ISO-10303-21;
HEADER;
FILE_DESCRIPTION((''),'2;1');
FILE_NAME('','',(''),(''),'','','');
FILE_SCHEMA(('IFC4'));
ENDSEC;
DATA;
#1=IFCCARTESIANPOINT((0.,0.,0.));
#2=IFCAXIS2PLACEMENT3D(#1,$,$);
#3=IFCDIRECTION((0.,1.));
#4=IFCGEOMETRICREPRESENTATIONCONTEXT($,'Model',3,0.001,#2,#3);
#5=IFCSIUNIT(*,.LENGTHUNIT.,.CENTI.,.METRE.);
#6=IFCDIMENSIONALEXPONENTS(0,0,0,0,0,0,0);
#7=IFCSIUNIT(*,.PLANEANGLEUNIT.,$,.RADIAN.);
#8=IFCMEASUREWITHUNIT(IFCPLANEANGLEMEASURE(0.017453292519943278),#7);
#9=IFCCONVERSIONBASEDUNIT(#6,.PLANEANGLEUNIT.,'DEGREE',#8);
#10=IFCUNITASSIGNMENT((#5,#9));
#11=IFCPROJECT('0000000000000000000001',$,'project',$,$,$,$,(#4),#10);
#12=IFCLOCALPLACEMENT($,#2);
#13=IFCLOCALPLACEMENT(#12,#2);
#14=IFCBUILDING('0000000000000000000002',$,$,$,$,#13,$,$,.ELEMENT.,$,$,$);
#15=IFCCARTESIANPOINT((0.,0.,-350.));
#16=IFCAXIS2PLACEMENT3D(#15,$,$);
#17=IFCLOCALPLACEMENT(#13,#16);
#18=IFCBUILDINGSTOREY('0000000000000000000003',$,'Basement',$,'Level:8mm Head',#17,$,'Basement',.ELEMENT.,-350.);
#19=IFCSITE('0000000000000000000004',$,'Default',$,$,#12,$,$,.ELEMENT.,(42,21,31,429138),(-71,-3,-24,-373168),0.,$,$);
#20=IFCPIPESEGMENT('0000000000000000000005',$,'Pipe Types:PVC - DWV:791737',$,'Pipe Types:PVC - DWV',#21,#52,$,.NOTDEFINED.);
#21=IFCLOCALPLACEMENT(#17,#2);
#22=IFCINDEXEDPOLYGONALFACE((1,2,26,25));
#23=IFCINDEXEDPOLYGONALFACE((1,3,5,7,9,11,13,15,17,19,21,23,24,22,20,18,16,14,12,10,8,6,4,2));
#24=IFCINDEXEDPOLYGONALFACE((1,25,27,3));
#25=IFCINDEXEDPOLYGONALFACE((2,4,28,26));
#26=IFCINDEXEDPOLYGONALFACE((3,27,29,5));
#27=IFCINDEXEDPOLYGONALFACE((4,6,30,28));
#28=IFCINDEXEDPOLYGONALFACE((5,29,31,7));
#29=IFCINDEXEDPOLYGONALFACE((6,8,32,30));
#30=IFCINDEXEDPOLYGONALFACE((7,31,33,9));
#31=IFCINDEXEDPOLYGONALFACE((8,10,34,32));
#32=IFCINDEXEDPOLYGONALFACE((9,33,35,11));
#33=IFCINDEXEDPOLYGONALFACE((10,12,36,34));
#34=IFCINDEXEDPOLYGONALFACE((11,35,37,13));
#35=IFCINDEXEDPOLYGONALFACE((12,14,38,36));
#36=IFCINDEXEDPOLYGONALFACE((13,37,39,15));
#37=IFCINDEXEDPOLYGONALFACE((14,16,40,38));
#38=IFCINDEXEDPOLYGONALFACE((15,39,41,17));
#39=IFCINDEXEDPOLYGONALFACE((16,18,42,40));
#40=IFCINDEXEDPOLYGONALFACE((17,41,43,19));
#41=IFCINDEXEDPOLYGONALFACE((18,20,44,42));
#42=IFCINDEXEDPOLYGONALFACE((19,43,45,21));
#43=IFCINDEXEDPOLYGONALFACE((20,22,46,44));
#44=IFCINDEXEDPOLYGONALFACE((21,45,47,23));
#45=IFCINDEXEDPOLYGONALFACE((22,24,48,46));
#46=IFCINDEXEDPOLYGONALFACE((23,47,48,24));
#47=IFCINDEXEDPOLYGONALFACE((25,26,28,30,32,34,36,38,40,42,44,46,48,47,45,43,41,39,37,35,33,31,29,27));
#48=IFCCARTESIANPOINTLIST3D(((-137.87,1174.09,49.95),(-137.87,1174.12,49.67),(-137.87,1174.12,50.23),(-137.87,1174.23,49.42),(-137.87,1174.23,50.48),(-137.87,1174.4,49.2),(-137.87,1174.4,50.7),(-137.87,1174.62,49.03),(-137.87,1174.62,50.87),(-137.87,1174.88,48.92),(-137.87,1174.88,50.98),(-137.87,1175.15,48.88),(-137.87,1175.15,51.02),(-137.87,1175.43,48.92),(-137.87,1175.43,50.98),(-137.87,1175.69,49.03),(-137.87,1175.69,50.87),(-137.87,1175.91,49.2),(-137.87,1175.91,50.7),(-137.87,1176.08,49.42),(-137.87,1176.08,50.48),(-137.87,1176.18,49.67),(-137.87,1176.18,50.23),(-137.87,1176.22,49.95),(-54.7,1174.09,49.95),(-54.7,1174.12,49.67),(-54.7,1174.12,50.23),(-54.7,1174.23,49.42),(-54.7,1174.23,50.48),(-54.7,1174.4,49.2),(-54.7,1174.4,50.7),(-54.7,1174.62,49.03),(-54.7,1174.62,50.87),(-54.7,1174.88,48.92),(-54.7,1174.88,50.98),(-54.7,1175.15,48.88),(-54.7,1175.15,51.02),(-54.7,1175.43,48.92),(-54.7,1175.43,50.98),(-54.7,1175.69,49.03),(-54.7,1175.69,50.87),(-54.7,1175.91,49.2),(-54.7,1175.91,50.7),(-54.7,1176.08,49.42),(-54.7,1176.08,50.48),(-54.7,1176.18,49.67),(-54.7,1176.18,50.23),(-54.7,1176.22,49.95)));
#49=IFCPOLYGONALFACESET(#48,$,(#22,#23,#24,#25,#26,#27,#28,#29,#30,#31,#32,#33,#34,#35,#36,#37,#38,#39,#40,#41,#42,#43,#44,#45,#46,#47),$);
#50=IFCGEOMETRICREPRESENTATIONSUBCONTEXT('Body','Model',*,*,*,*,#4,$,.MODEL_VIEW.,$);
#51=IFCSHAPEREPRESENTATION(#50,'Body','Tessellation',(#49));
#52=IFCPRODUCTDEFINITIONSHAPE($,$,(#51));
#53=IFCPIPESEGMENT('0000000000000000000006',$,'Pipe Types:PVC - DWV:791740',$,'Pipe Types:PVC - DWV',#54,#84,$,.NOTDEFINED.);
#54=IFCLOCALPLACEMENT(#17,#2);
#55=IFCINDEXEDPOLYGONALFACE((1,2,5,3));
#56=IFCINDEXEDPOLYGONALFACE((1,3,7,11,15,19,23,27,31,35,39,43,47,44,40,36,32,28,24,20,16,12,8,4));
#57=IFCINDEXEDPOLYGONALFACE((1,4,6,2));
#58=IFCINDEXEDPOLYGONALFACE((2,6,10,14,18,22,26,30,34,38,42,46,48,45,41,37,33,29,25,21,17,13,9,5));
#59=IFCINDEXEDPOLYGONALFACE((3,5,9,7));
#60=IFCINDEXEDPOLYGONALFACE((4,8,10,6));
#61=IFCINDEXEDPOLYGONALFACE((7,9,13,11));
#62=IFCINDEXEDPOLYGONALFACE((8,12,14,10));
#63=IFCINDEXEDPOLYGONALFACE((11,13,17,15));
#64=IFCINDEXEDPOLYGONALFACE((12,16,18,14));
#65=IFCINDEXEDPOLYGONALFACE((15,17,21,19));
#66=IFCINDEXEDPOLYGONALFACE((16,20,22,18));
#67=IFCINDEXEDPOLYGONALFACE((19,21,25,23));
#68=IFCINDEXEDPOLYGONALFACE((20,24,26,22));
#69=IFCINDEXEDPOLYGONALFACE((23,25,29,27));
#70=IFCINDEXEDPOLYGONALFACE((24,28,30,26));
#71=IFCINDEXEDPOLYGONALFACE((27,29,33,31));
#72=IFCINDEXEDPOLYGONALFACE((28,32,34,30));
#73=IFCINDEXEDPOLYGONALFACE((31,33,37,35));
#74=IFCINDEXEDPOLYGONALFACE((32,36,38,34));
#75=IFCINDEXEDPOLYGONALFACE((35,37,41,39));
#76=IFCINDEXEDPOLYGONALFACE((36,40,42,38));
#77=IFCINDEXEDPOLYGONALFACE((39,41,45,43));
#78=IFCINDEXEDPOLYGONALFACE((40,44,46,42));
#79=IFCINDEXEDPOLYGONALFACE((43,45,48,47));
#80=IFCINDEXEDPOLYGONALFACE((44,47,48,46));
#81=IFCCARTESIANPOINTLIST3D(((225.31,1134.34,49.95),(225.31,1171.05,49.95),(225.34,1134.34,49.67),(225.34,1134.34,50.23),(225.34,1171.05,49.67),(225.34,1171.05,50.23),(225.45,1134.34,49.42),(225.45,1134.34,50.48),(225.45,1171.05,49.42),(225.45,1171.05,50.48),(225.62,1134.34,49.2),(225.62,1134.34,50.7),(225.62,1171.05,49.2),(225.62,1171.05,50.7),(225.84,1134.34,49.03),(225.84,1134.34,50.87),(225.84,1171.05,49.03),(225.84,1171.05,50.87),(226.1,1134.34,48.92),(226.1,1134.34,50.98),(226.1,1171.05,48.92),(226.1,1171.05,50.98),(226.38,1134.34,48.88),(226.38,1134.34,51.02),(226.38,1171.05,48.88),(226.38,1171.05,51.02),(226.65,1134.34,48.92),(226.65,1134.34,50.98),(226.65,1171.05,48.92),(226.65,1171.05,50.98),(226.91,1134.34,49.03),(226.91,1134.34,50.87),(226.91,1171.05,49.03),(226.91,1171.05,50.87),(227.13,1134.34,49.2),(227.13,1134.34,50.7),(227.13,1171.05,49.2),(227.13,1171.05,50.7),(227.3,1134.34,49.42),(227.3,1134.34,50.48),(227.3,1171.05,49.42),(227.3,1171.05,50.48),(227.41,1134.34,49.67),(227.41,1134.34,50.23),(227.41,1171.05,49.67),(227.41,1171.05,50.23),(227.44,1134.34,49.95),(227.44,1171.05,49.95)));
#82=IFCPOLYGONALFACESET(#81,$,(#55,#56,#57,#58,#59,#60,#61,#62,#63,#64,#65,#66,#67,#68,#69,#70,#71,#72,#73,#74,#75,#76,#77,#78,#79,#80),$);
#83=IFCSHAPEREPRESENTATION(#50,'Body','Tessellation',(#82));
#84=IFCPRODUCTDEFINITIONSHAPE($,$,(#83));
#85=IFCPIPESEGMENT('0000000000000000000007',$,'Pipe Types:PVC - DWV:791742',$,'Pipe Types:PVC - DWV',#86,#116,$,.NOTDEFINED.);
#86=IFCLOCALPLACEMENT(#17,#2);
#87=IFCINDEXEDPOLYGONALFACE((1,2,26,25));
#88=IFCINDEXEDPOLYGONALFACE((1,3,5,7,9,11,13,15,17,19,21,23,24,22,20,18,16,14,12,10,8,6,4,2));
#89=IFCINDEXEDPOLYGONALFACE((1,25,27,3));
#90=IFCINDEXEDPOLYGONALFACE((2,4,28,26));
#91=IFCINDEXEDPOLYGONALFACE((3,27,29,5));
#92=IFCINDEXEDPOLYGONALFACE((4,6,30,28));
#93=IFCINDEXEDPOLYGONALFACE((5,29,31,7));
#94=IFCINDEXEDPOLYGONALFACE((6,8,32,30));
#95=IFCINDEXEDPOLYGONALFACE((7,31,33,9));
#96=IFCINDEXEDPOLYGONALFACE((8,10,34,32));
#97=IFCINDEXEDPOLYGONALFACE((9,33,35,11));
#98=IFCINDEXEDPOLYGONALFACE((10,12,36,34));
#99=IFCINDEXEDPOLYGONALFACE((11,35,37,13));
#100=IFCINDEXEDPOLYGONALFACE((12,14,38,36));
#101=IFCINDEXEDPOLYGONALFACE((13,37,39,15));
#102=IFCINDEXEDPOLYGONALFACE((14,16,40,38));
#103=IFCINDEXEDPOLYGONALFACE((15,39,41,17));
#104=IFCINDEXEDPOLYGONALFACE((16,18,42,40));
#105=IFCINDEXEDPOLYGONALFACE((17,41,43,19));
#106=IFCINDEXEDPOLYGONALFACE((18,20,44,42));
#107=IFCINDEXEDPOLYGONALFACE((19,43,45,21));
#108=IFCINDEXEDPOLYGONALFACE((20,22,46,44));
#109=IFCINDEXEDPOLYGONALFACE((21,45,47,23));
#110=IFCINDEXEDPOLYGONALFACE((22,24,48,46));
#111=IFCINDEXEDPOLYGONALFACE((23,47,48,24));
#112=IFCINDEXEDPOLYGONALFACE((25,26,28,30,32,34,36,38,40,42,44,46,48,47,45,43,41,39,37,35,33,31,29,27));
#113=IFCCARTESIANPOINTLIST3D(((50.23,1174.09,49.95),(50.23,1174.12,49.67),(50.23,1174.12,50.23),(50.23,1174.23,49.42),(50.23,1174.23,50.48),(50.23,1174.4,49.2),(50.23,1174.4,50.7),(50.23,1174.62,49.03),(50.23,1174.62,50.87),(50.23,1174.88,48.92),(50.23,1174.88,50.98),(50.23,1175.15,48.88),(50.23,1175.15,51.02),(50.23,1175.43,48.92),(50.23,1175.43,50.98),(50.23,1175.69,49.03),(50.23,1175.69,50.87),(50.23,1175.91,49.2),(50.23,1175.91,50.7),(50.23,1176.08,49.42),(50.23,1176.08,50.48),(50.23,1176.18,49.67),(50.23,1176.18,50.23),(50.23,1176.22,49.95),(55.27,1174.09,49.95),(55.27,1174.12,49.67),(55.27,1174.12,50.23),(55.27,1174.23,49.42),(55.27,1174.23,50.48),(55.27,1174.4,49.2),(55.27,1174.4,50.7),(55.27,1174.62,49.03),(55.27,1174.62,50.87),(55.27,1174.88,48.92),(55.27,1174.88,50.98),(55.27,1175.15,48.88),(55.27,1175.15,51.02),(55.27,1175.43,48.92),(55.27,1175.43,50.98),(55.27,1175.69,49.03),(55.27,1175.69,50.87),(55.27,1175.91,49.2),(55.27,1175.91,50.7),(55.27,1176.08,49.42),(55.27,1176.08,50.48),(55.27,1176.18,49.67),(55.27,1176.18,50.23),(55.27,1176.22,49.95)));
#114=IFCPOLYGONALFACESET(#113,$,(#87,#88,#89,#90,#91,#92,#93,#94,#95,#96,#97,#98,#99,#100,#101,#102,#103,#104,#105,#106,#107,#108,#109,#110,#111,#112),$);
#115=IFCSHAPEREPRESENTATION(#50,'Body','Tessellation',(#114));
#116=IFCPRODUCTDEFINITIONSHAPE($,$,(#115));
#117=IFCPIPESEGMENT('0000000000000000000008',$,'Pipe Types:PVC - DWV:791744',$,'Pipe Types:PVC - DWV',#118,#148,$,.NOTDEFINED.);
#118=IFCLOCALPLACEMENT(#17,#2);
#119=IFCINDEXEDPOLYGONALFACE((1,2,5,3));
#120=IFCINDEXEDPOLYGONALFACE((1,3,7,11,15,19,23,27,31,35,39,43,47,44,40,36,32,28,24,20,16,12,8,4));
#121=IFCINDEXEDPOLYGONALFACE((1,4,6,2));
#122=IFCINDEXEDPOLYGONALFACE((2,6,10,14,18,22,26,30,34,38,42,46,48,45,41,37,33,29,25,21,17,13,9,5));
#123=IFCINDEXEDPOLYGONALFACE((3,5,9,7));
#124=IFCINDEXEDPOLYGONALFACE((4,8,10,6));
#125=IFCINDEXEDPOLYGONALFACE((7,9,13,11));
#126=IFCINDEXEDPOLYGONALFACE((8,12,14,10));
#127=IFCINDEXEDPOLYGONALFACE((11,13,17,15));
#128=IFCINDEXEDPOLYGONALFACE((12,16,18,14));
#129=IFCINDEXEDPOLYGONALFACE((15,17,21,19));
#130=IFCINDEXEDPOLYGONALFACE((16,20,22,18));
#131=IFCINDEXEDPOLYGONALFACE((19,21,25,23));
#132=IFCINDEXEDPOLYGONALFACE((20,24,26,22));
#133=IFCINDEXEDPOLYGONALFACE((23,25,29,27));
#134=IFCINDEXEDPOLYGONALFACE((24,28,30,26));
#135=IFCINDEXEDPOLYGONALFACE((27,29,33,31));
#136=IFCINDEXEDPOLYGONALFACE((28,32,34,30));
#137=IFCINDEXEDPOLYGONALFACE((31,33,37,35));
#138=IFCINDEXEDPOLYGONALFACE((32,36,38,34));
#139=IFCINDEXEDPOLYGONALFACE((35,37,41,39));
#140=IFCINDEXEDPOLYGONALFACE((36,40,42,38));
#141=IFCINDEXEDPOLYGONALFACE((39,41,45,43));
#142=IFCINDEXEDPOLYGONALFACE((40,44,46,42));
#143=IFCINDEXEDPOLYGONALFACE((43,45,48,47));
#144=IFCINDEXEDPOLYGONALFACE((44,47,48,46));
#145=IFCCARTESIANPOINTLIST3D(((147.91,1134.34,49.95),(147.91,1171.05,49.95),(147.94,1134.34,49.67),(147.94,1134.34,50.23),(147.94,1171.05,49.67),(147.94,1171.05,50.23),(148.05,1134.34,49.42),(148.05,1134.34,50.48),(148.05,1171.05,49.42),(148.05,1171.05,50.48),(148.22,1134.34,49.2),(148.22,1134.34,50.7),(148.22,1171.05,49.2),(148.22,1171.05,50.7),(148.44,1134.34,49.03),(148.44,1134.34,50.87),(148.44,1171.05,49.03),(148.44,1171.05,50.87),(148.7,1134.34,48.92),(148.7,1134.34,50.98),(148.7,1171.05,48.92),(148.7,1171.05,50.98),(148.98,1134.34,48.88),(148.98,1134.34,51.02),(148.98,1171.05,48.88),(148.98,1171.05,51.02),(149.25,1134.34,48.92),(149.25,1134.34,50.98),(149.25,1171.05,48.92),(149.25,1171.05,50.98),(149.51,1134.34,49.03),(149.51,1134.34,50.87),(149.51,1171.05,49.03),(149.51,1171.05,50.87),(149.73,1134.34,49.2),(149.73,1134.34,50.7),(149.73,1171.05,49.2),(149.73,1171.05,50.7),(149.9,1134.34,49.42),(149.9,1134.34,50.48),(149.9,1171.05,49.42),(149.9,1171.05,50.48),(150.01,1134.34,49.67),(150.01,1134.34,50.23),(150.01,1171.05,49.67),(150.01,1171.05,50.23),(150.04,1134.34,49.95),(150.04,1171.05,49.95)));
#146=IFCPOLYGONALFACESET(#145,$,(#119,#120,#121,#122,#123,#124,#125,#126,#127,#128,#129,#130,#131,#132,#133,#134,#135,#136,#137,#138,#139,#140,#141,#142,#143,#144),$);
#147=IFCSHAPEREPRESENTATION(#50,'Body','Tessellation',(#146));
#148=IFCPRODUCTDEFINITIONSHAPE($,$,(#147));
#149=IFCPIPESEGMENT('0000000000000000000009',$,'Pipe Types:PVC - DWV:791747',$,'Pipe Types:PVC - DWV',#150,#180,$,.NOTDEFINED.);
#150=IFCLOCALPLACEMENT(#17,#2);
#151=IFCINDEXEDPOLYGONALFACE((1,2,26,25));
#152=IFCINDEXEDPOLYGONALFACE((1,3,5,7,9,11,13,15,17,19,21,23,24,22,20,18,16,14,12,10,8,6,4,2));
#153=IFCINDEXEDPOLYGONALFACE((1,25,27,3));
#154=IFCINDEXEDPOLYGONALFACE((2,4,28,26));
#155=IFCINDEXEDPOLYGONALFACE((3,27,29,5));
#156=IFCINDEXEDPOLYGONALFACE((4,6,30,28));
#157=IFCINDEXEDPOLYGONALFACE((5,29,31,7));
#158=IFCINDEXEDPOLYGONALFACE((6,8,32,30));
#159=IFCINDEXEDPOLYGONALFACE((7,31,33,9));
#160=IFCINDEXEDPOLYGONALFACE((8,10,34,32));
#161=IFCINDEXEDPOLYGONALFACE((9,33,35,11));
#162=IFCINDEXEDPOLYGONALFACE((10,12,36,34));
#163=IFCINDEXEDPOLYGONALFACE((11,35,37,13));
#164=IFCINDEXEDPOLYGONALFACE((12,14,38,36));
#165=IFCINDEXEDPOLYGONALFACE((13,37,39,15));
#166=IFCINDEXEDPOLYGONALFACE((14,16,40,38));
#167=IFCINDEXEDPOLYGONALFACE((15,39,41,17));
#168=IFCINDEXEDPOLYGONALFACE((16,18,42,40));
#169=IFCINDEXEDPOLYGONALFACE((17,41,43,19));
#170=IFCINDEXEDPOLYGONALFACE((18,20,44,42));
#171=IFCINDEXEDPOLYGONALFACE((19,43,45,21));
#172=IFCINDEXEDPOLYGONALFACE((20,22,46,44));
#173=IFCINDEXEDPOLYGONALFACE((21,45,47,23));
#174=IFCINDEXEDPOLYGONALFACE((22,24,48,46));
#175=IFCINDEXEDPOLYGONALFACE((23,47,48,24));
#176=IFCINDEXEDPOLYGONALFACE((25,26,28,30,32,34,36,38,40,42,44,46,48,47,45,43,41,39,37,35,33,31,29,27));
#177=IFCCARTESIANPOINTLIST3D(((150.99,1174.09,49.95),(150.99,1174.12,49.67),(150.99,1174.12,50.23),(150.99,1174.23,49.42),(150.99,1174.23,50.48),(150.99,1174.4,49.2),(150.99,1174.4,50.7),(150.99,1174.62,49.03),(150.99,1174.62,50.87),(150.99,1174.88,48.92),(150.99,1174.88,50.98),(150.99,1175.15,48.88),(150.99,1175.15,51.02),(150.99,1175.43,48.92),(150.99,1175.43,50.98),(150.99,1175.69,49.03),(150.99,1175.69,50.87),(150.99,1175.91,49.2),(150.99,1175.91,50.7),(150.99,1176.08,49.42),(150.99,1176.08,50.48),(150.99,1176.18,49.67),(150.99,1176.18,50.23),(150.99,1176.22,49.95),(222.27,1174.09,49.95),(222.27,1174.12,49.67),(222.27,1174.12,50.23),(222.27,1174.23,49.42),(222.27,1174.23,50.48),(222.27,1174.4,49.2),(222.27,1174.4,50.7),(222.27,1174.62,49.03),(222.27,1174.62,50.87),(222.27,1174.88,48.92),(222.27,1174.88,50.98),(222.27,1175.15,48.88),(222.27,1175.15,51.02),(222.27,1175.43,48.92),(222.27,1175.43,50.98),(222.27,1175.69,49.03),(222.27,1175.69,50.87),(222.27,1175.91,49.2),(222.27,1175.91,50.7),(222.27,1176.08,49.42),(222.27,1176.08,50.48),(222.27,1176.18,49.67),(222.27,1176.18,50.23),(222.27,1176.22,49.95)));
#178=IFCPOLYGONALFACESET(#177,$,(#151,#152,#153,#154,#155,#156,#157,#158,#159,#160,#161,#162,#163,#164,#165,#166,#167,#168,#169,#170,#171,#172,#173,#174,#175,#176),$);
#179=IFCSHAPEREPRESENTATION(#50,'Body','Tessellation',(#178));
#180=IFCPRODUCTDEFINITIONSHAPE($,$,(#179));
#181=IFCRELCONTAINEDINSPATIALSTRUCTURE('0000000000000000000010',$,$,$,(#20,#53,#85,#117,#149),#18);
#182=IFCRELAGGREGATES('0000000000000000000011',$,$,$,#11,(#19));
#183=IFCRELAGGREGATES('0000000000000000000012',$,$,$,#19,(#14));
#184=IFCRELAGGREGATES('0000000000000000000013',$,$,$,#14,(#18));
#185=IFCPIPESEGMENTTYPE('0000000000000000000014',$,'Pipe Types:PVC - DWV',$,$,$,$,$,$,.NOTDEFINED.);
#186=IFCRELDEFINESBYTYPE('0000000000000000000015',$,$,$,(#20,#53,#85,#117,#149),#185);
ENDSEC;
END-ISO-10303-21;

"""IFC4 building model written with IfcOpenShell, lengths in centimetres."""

from ifc_helpers import new_model, entity, si_unit, converted_unit, direction, frame, origin, place, context, subcontext, project, spatial, arc, indexed_curve, outline, extrude, type_object, element, save


model = new_model("IFC4")

# Units and contexts
model_context = context("Model", 3, precision=0.001, world=origin(), true_north=direction((0.0, 1.0)))
body_context = subcontext(model_context, "Body", "Model", "MODEL_VIEW")
ifc_project = project(units=[si_unit("LENGTHUNIT", "METRE", prefix="CENTI"), converted_unit("PLANEANGLEUNIT", "DEGREE", entity("IfcPlaneAngleMeasure", 0.017453292519943278), si_unit("PLANEANGLEUNIT", "RADIAN"), dimensions=[0, 0, 0, 0, 0, 0, 0])], contexts=[model_context])

# Site, building, storey
site_placement = place(None, origin())
site = spatial("IfcSite", under=ifc_project, at=site_placement, Name="Default", CompositionType="ELEMENT", RefLatitude=(42, 21, 31, 429138), RefLongitude=(-71, -3, -24, -373168), RefElevation=0.0)
building_placement = place(site_placement, origin())
building = spatial("IfcBuilding", under=site, at=building_placement, CompositionType="ELEMENT")
storey_placement = place(building_placement, frame((0.0, 0.0, -350.0)))
storey = spatial("IfcBuildingStorey", under=building, at=storey_placement, Name="Basement", ObjectType="Level:8mm Head", LongName="Basement", CompositionType="ELEMENT", Elevation=-350.0)

# Pipe segments
pipe_segment_type = type_object("IfcPipeSegmentType", Name="Pipe Types:PVC - DWV", PredefinedType="NOTDEFINED")
pipe_segment_1_placement = place(storey_placement, origin())
element("IfcPipeSegment", 1, at=pipe_segment_1_placement, inside=storey, type_object=pipe_segment_type, Name="Pipe Types:PVC - DWV:791737", ObjectType="Pipe Types:PVC - DWV", PredefinedType="NOTDEFINED", context=body_context, shape_type="SweptSolid", body=[
    extrude(outline(indexed_curve([(1.07, 0.0), (0.75, 0.75), (0.0, 1.07), (-0.75, 0.75), (-1.07, 0.0), (-0.75, -0.75), (0.0, -1.07), (0.75, -0.75)], segments=[arc(1, 2, 3), arc(3, 4, 5), arc(5, 6, 7), arc(7, 8, 1)], self_intersect=False)), frame((-137.87, 1175.15, 49.95), z_axis=(1.0, 0.0, 0.0), x_axis=(0.0, -1.0, 0.0)), (0.0, 0.0, 1.0), 83.17),
])
pipe_segment_2_placement = place(storey_placement, origin())
element("IfcPipeSegment", 2, at=pipe_segment_2_placement, inside=storey, type_object=pipe_segment_type, Name="Pipe Types:PVC - DWV:791740", ObjectType="Pipe Types:PVC - DWV", PredefinedType="NOTDEFINED", context=body_context, shape_type="SweptSolid", body=[
    extrude(outline(indexed_curve([(1.07, 0.0), (0.75, 0.75), (0.0, 1.07), (-0.75, 0.75), (-1.07, 0.0), (-0.75, -0.75), (0.0, -1.07), (0.75, -0.75)], segments=[arc(1, 2, 3), arc(3, 4, 5), arc(5, 6, 7), arc(7, 8, 1)], self_intersect=False)), frame((226.38, 1134.34, 49.95), z_axis=(0.0, 1.0, 0.0), x_axis=(-1.0, 0.0, 0.0)), (0.0, 0.0, 1.0), 36.71),
])
pipe_segment_3_placement = place(storey_placement, origin())
element("IfcPipeSegment", 3, at=pipe_segment_3_placement, inside=storey, type_object=pipe_segment_type, Name="Pipe Types:PVC - DWV:791742", ObjectType="Pipe Types:PVC - DWV", PredefinedType="NOTDEFINED", context=body_context, shape_type="SweptSolid", body=[
    extrude(outline(indexed_curve([(1.07, 0.0), (0.75, 0.75), (0.0, 1.07), (-0.75, 0.75), (-1.07, 0.0), (-0.75, -0.75), (0.0, -1.07), (0.75, -0.75)], segments=[arc(1, 2, 3), arc(3, 4, 5), arc(5, 6, 7), arc(7, 8, 1)], self_intersect=False)), frame((50.23, 1175.15, 49.95), z_axis=(1.0, 0.0, 0.0), x_axis=(0.0, 1.0, 0.0)), (0.0, 0.0, 1.0), 5.04),
])
pipe_segment_4_placement = place(storey_placement, origin())
element("IfcPipeSegment", 4, at=pipe_segment_4_placement, inside=storey, type_object=pipe_segment_type, Name="Pipe Types:PVC - DWV:791744", ObjectType="Pipe Types:PVC - DWV", PredefinedType="NOTDEFINED", context=body_context, shape_type="SweptSolid", body=[
    extrude(outline(indexed_curve([(1.07, 0.0), (0.75, 0.75), (0.0, 1.07), (-0.75, 0.75), (-1.07, 0.0), (-0.75, -0.75), (0.0, -1.07), (0.75, -0.75)], segments=[arc(1, 2, 3), arc(3, 4, 5), arc(5, 6, 7), arc(7, 8, 1)], self_intersect=False)), frame((148.98, 1134.34, 49.95), z_axis=(0.0, 1.0, 0.0), x_axis=(-1.0, 0.0, 0.0)), (0.0, 0.0, 1.0), 36.71),
])
pipe_segment_5_placement = place(storey_placement, origin())
element("IfcPipeSegment", 5, at=pipe_segment_5_placement, inside=storey, type_object=pipe_segment_type, Name="Pipe Types:PVC - DWV:791747", ObjectType="Pipe Types:PVC - DWV", PredefinedType="NOTDEFINED", context=body_context, shape_type="SweptSolid", body=[
    extrude(outline(indexed_curve([(1.07, 0.0), (0.75, 0.75), (0.0, 1.07), (-0.75, 0.75), (-1.07, 0.0), (-0.75, -0.75), (0.0, -1.07), (0.75, -0.75)], segments=[arc(1, 2, 3), arc(3, 4, 5), arc(5, 6, 7), arc(7, 8, 1)], self_intersect=False)), frame((150.99, 1175.15, 49.95), z_axis=(1.0, 0.0, 0.0), x_axis=(0.0, 1.0, 0.0)), (0.0, 0.0, 1.0), 71.29),
])

save(model, "model.ifc")
